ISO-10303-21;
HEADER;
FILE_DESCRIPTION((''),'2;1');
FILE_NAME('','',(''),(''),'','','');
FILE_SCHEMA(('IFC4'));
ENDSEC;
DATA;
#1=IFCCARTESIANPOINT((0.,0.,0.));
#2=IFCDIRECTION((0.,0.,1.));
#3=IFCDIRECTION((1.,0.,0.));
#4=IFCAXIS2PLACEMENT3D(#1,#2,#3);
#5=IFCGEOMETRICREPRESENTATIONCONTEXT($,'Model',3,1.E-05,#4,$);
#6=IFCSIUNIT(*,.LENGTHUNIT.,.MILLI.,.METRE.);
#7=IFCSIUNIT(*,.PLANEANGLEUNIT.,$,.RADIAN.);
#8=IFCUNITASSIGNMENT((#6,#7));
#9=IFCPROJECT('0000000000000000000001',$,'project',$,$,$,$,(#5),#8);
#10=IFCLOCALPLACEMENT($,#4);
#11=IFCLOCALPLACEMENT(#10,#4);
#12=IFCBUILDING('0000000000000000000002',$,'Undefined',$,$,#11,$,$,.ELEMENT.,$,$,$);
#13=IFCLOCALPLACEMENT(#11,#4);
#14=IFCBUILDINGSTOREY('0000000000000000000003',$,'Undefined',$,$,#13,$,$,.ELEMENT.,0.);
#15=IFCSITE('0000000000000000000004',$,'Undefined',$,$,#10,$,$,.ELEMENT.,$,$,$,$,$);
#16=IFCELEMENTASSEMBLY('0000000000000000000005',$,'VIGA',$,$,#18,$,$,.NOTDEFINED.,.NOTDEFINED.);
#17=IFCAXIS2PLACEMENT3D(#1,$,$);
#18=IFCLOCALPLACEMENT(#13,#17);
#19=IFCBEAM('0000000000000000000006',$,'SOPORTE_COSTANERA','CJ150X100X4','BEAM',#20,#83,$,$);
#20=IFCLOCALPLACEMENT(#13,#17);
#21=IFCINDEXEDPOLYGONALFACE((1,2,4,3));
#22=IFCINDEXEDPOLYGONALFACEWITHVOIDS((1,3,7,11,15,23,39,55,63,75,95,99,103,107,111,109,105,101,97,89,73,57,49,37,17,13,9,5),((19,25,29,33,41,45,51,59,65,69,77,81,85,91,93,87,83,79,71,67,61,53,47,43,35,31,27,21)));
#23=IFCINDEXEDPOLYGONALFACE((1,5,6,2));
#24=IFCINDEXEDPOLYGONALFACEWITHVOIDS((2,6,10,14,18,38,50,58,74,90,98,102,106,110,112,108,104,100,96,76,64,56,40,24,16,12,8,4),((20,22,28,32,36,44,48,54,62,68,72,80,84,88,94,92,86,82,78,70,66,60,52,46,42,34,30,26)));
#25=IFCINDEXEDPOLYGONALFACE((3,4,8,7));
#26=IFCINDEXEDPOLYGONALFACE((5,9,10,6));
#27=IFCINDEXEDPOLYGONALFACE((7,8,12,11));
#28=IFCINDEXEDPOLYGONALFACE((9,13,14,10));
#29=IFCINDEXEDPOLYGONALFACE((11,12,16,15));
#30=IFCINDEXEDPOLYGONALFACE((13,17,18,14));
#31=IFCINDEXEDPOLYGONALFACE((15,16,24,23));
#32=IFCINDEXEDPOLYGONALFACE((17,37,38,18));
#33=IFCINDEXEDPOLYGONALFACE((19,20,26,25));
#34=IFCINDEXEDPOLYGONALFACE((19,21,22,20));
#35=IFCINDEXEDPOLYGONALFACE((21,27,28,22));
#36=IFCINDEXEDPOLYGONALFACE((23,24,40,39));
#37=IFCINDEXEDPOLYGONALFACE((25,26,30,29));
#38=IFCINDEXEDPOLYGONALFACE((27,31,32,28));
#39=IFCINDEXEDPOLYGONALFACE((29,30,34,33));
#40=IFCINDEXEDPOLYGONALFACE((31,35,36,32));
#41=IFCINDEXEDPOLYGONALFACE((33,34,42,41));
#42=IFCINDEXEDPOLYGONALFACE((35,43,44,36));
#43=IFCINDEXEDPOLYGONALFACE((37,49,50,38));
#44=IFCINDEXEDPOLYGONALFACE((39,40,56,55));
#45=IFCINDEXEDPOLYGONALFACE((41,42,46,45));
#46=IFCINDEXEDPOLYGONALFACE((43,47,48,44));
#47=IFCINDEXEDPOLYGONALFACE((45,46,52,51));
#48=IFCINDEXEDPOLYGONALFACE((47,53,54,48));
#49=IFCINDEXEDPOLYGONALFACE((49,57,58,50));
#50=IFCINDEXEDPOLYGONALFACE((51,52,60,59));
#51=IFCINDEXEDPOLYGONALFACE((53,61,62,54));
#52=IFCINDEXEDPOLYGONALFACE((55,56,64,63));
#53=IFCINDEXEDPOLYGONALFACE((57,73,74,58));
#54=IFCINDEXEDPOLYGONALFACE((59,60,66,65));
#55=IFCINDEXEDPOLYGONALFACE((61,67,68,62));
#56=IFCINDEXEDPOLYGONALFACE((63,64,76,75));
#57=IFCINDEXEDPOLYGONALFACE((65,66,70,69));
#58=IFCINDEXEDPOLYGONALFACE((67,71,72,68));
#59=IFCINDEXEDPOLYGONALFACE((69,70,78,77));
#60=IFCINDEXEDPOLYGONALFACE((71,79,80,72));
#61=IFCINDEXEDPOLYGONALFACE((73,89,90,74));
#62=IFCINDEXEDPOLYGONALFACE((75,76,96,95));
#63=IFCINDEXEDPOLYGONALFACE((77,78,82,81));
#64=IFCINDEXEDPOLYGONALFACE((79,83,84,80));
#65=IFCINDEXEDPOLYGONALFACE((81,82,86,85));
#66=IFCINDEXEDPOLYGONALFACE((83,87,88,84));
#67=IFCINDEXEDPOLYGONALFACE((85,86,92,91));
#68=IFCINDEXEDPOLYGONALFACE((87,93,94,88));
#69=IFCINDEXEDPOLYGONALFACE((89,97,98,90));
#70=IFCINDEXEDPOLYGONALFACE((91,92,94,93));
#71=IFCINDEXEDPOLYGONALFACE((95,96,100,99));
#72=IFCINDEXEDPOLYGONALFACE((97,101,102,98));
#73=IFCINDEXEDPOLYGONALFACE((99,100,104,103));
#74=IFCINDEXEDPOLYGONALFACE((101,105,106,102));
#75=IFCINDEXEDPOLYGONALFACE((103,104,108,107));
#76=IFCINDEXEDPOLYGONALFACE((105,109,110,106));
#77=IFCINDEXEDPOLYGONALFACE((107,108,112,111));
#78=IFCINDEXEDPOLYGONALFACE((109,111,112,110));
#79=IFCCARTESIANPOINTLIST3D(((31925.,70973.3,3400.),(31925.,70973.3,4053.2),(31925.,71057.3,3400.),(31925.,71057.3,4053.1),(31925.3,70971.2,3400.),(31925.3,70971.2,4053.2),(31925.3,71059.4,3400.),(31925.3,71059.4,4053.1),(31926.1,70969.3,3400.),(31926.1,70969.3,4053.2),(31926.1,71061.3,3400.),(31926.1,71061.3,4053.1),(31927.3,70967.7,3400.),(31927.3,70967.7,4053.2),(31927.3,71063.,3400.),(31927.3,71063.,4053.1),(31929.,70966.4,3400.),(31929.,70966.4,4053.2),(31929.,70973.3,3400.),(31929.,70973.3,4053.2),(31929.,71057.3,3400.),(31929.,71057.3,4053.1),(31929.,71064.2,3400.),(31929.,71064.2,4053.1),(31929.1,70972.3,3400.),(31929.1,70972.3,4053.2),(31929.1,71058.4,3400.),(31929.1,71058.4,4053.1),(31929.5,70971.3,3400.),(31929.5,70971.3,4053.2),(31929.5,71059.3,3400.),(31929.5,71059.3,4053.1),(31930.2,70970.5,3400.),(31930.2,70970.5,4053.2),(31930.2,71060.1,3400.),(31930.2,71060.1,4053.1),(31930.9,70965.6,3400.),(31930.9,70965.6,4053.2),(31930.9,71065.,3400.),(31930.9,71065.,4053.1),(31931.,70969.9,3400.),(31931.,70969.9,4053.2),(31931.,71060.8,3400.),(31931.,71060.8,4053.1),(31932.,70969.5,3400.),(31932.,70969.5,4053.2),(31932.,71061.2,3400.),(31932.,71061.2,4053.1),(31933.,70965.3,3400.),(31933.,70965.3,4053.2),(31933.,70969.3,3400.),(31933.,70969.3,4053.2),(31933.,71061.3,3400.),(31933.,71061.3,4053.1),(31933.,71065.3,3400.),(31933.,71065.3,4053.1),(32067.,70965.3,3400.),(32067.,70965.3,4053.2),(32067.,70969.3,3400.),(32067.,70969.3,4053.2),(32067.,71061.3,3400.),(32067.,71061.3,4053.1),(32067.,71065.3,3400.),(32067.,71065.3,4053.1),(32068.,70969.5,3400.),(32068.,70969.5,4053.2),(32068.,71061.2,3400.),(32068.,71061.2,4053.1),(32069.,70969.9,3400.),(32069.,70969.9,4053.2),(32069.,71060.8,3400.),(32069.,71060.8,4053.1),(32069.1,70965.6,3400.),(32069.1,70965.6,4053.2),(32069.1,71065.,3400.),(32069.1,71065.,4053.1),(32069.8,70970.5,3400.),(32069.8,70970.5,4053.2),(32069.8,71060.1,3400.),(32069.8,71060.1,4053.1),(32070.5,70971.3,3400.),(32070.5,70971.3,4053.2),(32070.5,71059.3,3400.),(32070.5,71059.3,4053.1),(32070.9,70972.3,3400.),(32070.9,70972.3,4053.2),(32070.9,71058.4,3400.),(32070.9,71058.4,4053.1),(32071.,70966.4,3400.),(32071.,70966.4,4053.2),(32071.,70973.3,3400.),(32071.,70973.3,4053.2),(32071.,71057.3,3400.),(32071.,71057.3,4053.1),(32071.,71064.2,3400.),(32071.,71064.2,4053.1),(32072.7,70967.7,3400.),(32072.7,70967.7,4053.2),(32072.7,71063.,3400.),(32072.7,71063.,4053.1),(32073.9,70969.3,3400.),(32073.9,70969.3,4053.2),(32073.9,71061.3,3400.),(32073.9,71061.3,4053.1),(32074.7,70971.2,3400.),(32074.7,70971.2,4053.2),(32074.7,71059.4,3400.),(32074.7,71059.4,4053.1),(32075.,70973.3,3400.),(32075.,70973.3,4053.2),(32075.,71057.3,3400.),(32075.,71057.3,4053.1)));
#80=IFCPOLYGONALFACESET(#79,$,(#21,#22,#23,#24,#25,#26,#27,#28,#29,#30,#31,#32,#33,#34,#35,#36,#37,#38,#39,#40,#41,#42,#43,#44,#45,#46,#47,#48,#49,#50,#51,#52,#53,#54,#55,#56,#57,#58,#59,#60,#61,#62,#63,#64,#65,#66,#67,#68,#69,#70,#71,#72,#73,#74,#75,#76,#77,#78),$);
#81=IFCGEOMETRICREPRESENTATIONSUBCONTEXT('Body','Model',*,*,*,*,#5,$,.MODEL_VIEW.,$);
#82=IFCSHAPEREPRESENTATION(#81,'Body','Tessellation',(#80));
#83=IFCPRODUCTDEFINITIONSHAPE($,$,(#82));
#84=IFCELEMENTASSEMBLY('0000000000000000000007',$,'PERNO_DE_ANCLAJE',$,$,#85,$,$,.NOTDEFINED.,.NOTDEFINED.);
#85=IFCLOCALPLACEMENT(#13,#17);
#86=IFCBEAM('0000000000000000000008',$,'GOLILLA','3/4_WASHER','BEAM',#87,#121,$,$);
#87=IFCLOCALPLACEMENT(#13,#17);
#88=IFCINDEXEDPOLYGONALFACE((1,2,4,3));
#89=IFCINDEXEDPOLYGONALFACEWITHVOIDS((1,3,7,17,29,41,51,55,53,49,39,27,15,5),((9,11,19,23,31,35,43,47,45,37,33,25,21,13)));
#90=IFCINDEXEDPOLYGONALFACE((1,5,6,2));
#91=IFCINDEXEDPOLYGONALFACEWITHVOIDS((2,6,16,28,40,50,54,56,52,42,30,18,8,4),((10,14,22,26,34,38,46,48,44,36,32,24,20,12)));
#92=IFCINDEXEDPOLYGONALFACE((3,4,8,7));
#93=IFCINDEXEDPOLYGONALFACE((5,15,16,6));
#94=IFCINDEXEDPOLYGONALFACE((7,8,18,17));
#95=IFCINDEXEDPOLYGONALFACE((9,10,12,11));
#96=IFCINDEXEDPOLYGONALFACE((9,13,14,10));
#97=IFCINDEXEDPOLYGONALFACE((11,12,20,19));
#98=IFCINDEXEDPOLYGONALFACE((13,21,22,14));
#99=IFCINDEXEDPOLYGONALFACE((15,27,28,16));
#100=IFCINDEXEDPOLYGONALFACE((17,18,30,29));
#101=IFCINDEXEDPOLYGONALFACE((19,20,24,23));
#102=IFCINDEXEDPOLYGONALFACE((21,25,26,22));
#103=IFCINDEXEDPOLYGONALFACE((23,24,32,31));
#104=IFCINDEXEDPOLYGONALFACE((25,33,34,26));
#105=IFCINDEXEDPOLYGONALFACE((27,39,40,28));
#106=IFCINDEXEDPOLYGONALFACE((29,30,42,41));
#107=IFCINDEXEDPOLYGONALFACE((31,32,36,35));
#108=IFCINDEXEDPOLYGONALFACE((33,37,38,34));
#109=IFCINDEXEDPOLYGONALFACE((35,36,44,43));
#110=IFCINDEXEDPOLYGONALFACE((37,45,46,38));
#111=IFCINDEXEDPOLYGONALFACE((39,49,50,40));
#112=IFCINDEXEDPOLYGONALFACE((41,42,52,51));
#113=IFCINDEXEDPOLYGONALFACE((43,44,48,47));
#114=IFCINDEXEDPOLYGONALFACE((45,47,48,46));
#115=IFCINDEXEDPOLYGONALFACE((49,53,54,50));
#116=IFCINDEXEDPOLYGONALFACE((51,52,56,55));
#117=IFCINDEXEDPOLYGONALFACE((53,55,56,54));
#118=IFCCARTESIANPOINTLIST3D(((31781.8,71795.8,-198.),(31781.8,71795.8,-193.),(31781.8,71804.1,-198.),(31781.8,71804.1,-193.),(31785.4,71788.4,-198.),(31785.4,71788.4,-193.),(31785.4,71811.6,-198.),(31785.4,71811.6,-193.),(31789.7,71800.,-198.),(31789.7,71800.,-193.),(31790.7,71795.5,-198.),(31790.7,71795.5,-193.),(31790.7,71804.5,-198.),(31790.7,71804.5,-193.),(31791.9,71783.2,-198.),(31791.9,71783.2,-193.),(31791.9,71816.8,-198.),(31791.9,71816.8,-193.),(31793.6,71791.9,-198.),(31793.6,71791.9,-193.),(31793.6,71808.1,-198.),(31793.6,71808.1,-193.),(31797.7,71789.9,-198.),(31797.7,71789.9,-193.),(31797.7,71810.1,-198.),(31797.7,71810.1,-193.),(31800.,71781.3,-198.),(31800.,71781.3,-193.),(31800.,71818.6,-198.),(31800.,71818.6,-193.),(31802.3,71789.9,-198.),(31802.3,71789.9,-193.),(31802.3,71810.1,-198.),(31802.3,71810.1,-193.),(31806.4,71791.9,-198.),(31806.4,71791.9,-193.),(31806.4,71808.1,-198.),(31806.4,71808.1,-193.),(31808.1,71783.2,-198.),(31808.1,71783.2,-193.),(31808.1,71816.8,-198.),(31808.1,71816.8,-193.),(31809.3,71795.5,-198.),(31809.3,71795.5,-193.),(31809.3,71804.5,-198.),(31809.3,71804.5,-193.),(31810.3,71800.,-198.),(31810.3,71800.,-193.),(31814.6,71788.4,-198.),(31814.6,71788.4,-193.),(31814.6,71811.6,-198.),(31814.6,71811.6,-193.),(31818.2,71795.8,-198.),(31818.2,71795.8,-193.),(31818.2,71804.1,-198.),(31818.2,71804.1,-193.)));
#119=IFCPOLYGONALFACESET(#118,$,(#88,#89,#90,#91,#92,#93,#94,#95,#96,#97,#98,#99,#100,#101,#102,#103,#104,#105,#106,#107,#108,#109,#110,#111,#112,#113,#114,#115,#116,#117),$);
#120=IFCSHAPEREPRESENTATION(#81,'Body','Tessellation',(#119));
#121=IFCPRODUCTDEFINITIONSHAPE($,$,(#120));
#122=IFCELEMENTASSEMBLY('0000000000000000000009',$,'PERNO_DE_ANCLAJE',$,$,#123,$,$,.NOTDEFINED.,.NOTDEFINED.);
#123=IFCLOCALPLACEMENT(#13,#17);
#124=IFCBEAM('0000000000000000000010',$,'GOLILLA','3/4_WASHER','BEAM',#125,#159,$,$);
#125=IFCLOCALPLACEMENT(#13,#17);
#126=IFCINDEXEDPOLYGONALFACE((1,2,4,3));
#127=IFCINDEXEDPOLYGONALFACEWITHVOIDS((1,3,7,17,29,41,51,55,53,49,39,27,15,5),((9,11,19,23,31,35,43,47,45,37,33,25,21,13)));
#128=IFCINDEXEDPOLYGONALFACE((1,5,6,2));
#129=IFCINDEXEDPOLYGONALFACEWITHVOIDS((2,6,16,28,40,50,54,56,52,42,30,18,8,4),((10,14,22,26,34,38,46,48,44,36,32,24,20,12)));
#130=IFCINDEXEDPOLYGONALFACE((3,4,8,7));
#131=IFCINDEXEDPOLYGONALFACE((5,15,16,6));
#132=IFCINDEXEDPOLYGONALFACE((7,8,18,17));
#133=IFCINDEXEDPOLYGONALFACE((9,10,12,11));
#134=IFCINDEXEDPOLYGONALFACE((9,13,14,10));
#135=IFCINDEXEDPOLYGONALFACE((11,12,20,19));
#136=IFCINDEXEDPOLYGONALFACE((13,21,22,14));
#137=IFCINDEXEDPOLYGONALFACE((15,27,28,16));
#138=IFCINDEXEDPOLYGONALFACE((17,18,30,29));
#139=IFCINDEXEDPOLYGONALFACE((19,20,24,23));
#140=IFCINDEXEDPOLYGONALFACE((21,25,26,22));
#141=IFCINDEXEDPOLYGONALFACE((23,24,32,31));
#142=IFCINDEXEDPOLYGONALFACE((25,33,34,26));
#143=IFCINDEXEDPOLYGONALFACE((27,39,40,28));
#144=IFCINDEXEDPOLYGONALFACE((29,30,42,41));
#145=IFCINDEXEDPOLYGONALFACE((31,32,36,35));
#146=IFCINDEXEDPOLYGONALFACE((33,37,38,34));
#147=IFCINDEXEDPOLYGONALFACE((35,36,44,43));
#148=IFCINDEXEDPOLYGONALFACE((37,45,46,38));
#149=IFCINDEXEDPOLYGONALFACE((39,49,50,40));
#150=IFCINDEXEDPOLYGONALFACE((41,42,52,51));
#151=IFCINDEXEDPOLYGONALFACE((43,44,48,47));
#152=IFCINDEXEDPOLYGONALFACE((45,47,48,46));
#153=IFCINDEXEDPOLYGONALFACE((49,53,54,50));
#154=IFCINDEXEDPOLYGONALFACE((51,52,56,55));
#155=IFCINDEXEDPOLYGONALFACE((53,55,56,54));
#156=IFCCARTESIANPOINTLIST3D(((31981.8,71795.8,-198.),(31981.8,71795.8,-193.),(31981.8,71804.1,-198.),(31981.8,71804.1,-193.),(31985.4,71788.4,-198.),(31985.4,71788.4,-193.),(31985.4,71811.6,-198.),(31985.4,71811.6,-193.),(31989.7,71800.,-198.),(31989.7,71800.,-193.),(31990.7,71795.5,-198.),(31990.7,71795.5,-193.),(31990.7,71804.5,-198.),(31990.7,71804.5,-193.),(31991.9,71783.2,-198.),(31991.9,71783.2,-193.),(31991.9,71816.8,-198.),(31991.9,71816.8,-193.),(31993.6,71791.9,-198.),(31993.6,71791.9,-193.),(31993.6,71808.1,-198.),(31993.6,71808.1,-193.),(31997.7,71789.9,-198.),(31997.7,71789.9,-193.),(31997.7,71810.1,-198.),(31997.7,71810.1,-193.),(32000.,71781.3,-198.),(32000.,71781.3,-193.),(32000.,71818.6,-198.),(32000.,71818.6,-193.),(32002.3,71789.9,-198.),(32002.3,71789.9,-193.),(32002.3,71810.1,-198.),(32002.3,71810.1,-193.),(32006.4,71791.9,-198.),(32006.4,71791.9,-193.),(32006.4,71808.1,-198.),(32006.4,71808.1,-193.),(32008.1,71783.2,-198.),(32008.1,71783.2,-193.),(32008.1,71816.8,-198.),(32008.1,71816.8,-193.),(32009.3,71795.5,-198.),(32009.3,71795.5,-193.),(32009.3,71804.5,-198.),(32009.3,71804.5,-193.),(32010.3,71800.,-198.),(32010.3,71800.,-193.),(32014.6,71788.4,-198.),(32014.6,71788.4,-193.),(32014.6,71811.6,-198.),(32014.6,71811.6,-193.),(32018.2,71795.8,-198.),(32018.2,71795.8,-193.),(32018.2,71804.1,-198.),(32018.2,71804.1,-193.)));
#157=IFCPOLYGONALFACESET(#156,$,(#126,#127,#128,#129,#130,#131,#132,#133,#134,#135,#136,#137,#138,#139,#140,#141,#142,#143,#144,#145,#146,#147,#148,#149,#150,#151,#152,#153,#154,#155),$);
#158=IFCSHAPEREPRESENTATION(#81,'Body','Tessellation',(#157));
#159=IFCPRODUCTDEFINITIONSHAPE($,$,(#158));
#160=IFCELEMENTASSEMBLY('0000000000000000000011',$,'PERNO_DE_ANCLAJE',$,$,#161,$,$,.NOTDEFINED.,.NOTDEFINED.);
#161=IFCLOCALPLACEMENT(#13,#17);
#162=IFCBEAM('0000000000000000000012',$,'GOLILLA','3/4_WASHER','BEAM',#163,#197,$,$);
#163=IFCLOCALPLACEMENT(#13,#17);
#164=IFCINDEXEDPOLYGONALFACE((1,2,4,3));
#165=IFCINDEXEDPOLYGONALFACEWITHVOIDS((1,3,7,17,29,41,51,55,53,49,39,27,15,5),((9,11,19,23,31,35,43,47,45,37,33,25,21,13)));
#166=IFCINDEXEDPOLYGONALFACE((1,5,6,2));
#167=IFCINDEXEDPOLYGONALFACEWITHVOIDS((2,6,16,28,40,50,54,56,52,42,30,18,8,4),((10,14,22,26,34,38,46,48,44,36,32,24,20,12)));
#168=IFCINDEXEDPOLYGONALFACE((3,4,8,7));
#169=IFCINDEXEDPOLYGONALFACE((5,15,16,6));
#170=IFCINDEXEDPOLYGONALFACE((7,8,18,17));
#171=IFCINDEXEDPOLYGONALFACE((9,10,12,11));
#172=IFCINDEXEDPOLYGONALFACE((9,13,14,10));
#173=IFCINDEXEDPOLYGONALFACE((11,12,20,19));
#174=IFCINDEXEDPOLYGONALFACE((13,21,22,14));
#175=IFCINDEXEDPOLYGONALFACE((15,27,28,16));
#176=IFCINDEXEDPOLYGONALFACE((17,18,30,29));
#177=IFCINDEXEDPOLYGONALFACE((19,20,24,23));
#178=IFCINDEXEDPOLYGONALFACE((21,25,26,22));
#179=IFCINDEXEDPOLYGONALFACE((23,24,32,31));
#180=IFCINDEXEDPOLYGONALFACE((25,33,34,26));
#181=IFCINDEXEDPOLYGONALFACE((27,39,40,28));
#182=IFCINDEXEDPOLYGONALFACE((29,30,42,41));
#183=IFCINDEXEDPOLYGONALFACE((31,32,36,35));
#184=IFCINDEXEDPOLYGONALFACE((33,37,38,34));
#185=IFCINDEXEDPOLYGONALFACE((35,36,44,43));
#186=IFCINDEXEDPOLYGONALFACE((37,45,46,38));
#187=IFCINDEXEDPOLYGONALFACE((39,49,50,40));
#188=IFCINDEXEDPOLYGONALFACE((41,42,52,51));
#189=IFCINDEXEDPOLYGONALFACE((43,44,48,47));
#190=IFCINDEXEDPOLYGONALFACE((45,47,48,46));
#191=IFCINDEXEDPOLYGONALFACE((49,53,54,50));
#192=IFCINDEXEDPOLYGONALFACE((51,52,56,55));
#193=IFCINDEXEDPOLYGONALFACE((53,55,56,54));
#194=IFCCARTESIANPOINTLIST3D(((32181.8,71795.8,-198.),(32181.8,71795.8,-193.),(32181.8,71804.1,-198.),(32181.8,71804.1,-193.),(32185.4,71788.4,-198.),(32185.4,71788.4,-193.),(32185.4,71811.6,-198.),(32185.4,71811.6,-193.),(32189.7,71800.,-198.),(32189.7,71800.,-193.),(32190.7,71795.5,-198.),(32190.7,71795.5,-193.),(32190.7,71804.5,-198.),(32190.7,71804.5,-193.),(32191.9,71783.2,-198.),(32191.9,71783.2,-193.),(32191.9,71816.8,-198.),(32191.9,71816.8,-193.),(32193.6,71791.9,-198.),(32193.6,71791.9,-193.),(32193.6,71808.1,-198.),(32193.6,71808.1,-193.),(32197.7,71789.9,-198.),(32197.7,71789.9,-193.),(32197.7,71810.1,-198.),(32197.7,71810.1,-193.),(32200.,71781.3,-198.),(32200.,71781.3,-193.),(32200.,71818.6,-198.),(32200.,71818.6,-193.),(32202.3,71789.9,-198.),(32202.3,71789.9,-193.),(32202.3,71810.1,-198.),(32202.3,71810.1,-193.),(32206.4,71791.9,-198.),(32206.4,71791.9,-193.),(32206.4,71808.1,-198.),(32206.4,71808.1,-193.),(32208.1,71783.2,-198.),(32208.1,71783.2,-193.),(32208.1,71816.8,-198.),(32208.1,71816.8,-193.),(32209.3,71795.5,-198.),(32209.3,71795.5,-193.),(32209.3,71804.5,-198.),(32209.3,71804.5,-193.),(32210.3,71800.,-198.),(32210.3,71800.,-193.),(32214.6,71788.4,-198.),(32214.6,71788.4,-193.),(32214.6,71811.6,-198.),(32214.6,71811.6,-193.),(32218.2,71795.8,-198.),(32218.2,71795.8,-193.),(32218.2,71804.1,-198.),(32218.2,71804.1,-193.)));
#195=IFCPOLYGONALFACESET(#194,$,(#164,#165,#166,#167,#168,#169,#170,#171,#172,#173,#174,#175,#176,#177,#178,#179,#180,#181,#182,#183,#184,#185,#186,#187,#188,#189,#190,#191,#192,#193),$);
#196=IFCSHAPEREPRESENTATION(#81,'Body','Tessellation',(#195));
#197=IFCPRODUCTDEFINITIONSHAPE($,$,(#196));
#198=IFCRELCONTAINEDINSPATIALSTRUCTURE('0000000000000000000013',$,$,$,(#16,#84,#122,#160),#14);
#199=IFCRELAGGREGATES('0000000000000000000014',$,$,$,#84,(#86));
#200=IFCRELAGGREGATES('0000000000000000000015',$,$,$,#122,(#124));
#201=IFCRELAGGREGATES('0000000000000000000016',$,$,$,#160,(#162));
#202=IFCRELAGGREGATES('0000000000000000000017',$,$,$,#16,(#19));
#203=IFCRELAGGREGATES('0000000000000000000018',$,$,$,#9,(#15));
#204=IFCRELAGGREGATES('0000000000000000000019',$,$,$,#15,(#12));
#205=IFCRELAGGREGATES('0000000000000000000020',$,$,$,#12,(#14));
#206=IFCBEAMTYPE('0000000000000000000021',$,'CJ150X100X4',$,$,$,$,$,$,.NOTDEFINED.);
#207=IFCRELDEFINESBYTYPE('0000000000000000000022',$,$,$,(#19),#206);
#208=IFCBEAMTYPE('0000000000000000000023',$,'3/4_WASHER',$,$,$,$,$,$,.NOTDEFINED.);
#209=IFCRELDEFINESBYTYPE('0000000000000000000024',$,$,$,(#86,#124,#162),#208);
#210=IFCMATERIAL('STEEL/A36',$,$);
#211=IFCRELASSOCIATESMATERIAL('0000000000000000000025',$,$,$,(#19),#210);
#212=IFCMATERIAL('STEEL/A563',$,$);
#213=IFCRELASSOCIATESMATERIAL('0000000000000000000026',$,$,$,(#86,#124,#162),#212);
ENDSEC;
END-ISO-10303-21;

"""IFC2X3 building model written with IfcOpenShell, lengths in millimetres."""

from ifc_helpers import new_model, si_unit, frame, origin_with_axes, origin_2d_with_axis, place, context, subcontext, project, spatial, polyline, hollow_rectangle, outline, extrude, material, type_object, element, aggregate, save


model = new_model("IFC2X3")

# Units and contexts
model_context = context("Model", 3, precision=1e-05, world=origin_with_axes())
body_context = subcontext(model_context, "Body", "Model", "MODEL_VIEW")
ifc_project = project(units=[si_unit("LENGTHUNIT", "METRE", prefix="MILLI"), si_unit("PLANEANGLEUNIT", "RADIAN")], contexts=[model_context])

# Site, building, storey
site_placement = place(None, origin_with_axes())
site = spatial("IfcSite", under=ifc_project, at=site_placement, Name="Undefined", CompositionType="ELEMENT")
building_placement = place(site_placement, origin_with_axes())
building = spatial("IfcBuilding", under=site, at=building_placement, Name="Undefined", CompositionType="ELEMENT")
storey_placement = place(building_placement, origin_with_axes())
storey = spatial("IfcBuildingStorey", under=building, at=storey_placement, Name="Undefined", CompositionType="ELEMENT", Elevation=0.0)

# Element assemblies, beams
assembly_1_placement = place(storey_placement, origin_with_axes())
assembly_1 = element("IfcElementAssembly", 1, at=assembly_1_placement, inside=storey, Name="VIGA", AssemblyPlace="NOTDEFINED", PredefinedType="NOTDEFINED")
ifc_material_1 = material(Name="STEEL/A36")
beam_type_1 = type_object("IfcBeamType", Name="CJ150X100X4", PredefinedType="NOTDEFINED")
beam_1_placement = place(assembly_1_placement, frame((32000.0, 71015.3, 4053.1), z_axis=(-1.0, 0.0, 0.0), x_axis=(0.0, 0.0, -1.0)))
beam_1 = element("IfcBeam", 2, at=beam_1_placement, type_object=beam_type_1, material=ifc_material_1, Name="SOPORTE_COSTANERA", Description="CJ150X100X4", ObjectType="BEAM", context=body_context, shape_type="SweptSolid", body=[
    extrude(hollow_rectangle(XDim=100.0, YDim=150.0, WallThickness=4.0, InnerFilletRadius=4.0, OuterFilletRadius=8.0, at=origin_2d_with_axis()), frame((653.1, 0.0, 0.0), z_axis=(-1.0, 0.0, 0.0), x_axis=(0.0, -1.0, 0.0)), (0.0, 0.0, 1.0), 653.1),
])
assembly_2_placement = place(storey_placement, origin_with_axes())
assembly_2 = element("IfcElementAssembly", 3, at=assembly_2_placement, inside=storey, Name="PERNO_DE_ANCLAJE", AssemblyPlace="NOTDEFINED", PredefinedType="NOTDEFINED")
ifc_material_2 = material(Name="STEEL/A563")
beam_type_2 = type_object("IfcBeamType", Name="3/4_WASHER", PredefinedType="NOTDEFINED")
beam_2_placement = place(assembly_2_placement, frame((31800.0, 71800.0, -193.0), z_axis=(1.0, 0.0, 0.0), x_axis=(0.0, 0.00008, -1.0)))
beam_2 = element("IfcBeam", 4, at=beam_2_placement, type_object=beam_type_2, material=ifc_material_2, Name="GOLILLA", Description="3/4_WASHER", ObjectType="BEAM", context=body_context, shape_type="SweptSolid", body=[
    extrude(outline(polyline([(-16.8, 8.1), (-11.6, 14.6), (-4.2, 18.2), (4.2, 18.2), (11.6, 14.6), (16.8, 8.1), (18.6, 0.0), (16.8, -8.1), (11.6, -14.6), (4.2, -18.2), (-4.2, -18.2), (-11.6, -14.6), (-16.8, -8.1), (-18.6, 0.0), (-16.8, 8.1)]), holes=[polyline([(8.1, 6.4), (4.5, 9.3), (0.0, 10.3), (-4.5, 9.3), (-8.1, 6.4), (-10.1, 2.3), (-10.1, -2.3), (-8.1, -6.4), (-4.5, -9.3), (0.0, -10.3), (4.5, -9.3), (8.1, -6.4), (10.1, -2.3), (10.1, 2.3), (8.1, 6.4)])]), frame((5.0, 0.0, 0.0), z_axis=(-1.0, 0.0, 0.0), x_axis=(0.0, -1.0, 0.0)), (0.0, 0.0, 1.0), 5.0),
])
assembly_3_placement = place(storey_placement, origin_with_axes())
assembly_3 = element("IfcElementAssembly", 5, at=assembly_3_placement, inside=storey, Name="PERNO_DE_ANCLAJE", AssemblyPlace="NOTDEFINED", PredefinedType="NOTDEFINED")
beam_3_placement = place(assembly_3_placement, frame((32000.0, 71800.0, -193.0), z_axis=(1.0, 0.0, 0.0), x_axis=(0.0, 0.00008, -1.0)))
beam_3 = element("IfcBeam", 6, at=beam_3_placement, type_object=beam_type_2, material=ifc_material_2, Name="GOLILLA", Description="3/4_WASHER", ObjectType="BEAM", context=body_context, shape_type="SweptSolid", body=[
    extrude(outline(polyline([(-16.8, 8.1), (-11.6, 14.6), (-4.2, 18.2), (4.2, 18.2), (11.6, 14.6), (16.8, 8.1), (18.6, 0.0), (16.8, -8.1), (11.6, -14.6), (4.2, -18.2), (-4.2, -18.2), (-11.6, -14.6), (-16.8, -8.1), (-18.6, 0.0), (-16.8, 8.1)]), holes=[polyline([(8.1, 6.4), (4.5, 9.3), (0.0, 10.3), (-4.5, 9.3), (-8.1, 6.4), (-10.1, 2.3), (-10.1, -2.3), (-8.1, -6.4), (-4.5, -9.3), (0.0, -10.3), (4.5, -9.3), (8.1, -6.4), (10.1, -2.3), (10.1, 2.3), (8.1, 6.4)])]), frame((5.0, 0.0, 0.0), z_axis=(-1.0, 0.0, 0.0), x_axis=(0.0, -1.0, 0.0)), (0.0, 0.0, 1.0), 5.0),
])
assembly_4_placement = place(storey_placement, origin_with_axes())
assembly_4 = element("IfcElementAssembly", 7, at=assembly_4_placement, inside=storey, Name="PERNO_DE_ANCLAJE", AssemblyPlace="NOTDEFINED", PredefinedType="NOTDEFINED")
beam_4_placement = place(assembly_4_placement, frame((32200.0, 71800.0, -193.0), z_axis=(1.0, 0.0, 0.0), x_axis=(0.0, 0.00008, -1.0)))
beam_4 = element("IfcBeam", 8, at=beam_4_placement, type_object=beam_type_2, material=ifc_material_2, Name="GOLILLA", Description="3/4_WASHER", ObjectType="BEAM", context=body_context, shape_type="SweptSolid", body=[
    extrude(outline(polyline([(-16.8, 8.1), (-11.6, 14.6), (-4.2, 18.2), (4.2, 18.2), (11.6, 14.6), (16.8, 8.1), (18.6, 0.0), (16.8, -8.1), (11.6, -14.6), (4.2, -18.2), (-4.2, -18.2), (-11.6, -14.6), (-16.8, -8.1), (-18.6, 0.0), (-16.8, 8.1)]), holes=[polyline([(8.1, 6.4), (4.5, 9.3), (0.0, 10.3), (-4.5, 9.3), (-8.1, 6.4), (-10.1, 2.3), (-10.1, -2.3), (-8.1, -6.4), (-4.5, -9.3), (0.0, -10.3), (4.5, -9.3), (8.1, -6.4), (10.1, -2.3), (10.1, 2.3), (8.1, 6.4)])]), frame((5.0, 0.0, 0.0), z_axis=(-1.0, 0.0, 0.0), x_axis=(0.0, -1.0, 0.0)), (0.0, 0.0, 1.0), 5.0),
])

aggregate(assembly_2, [beam_2])
aggregate(assembly_3, [beam_3])
aggregate(assembly_4, [beam_4])

aggregate(assembly_1, [beam_1])

save(model, "model.ifc")
